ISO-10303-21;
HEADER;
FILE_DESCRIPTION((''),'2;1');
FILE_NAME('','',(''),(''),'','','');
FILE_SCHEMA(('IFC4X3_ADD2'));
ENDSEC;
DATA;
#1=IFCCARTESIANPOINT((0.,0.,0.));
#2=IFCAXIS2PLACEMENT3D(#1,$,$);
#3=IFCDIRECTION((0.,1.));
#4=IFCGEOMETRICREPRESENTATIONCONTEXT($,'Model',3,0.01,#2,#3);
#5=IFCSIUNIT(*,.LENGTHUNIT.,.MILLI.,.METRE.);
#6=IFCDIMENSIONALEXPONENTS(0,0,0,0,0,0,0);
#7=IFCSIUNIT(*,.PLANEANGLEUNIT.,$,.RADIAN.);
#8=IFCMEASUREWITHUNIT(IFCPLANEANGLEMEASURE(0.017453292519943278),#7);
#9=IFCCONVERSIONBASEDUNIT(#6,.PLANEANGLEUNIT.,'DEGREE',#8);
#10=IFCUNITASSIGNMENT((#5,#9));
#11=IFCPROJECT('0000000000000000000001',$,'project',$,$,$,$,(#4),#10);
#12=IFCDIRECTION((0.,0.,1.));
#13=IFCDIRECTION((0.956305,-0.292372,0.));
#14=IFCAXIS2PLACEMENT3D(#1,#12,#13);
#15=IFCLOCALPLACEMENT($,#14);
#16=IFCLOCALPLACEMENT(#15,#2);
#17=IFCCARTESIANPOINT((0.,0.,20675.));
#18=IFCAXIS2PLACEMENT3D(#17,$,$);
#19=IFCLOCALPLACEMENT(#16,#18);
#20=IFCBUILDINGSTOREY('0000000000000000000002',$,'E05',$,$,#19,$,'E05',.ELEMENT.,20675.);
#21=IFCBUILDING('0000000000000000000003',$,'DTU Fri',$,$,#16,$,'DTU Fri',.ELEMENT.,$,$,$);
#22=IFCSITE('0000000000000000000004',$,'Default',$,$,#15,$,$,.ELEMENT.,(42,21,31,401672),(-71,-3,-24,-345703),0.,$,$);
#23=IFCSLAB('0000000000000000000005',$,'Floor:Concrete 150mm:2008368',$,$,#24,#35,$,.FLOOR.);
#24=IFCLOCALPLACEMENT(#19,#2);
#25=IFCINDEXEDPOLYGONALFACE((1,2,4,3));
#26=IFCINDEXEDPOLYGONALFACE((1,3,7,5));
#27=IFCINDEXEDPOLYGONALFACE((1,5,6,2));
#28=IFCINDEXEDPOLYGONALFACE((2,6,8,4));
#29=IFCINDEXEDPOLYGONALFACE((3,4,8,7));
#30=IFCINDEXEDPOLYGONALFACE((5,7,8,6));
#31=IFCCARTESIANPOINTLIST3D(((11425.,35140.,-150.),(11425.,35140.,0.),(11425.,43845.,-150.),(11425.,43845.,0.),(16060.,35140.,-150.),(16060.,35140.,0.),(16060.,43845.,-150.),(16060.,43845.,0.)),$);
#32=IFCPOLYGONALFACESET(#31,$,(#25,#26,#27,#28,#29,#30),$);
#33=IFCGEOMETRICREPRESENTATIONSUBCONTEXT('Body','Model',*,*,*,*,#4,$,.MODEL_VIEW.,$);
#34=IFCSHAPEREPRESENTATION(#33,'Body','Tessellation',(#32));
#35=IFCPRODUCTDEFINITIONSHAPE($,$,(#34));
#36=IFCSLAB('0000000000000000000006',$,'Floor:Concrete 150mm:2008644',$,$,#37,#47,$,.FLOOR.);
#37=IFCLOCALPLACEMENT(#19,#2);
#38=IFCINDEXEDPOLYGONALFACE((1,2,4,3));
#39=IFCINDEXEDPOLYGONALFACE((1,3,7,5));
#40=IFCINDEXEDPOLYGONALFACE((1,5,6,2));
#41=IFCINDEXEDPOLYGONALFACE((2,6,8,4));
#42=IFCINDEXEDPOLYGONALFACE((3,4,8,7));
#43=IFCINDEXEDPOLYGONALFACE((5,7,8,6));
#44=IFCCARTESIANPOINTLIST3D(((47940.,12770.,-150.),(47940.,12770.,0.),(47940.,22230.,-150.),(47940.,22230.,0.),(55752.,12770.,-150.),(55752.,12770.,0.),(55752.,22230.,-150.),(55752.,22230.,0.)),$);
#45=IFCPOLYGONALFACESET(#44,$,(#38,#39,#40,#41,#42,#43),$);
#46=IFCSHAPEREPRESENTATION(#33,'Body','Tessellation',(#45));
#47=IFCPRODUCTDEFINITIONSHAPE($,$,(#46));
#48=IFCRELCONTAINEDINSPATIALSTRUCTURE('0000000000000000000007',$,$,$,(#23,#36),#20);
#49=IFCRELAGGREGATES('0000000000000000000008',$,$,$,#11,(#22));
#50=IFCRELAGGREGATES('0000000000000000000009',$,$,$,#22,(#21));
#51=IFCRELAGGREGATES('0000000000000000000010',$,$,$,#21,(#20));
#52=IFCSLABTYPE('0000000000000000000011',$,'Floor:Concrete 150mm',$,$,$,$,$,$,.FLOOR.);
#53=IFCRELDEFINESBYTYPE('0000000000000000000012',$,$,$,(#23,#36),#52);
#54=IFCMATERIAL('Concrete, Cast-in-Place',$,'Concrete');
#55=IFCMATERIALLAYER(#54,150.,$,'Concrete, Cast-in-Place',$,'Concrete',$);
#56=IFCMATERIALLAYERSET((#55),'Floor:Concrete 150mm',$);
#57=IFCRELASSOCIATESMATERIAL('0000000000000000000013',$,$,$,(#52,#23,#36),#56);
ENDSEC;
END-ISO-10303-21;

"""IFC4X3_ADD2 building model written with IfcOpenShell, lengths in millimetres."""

from ifc_helpers import new_model, entity, si_unit, converted_unit, direction, frame, frame_2d, origin, place, context, subcontext, project, spatial, rectangle, extrude, material, layer, layer_set, layer_usage, type_object, element, save


model = new_model("IFC4X3_ADD2")

# Units and contexts
model_context = context("Model", 3, precision=0.01, world=origin(), true_north=direction((0.0, 1.0)))
body_context = subcontext(model_context, "Body", "Model", "MODEL_VIEW")
ifc_project = project(units=[si_unit("LENGTHUNIT", "METRE", prefix="MILLI"), converted_unit("PLANEANGLEUNIT", "DEGREE", entity("IfcPlaneAngleMeasure", 0.017453292519943278), si_unit("PLANEANGLEUNIT", "RADIAN"), dimensions=[0, 0, 0, 0, 0, 0, 0])], contexts=[model_context])

# Site, building, storey
site_placement = place(None, frame((0.0, 0.0, 0.0), z_axis=(0.0, 0.0, 1.0), x_axis=(0.956305, -0.292372, 0.0)))
site = spatial("IfcSite", under=ifc_project, at=site_placement, Name="Default", CompositionType="ELEMENT", RefLatitude=(42, 21, 31, 401672), RefLongitude=(-71, -3, -24, -345703), RefElevation=0.0)
building_placement = place(site_placement, origin())
building = spatial("IfcBuilding", under=site, at=building_placement, Name="DTU Fri", LongName="DTU Fri", CompositionType="ELEMENT")
storey_placement = place(building_placement, frame((0.0, 0.0, 20675.0)))
storey = spatial("IfcBuildingStorey", under=building, at=storey_placement, Name="E05", LongName="E05", CompositionType="ELEMENT", Elevation=20675.0)

# Slabs
ifc_material = material(Name="Concrete, Cast-in-Place", Category="Concrete")
ifc_layer = layer(ifc_material, 150.0, Name="Concrete, Cast-in-Place", Category="Concrete")
ifc_layer_set = layer_set([ifc_layer], Name="Floor:Concrete 150mm")
ifc_layer_usage_1 = layer_usage(ifc_layer_set, "AXIS3", "POSITIVE", 0.0)
slab_type = type_object("IfcSlabType", Name="Floor:Concrete 150mm", PredefinedType="FLOOR", material=ifc_layer_set)
slab_1_placement = place(storey_placement, origin())
element("IfcSlab", 1, at=slab_1_placement, inside=storey, type_object=slab_type, material=ifc_layer_usage_1, Name="Floor:Concrete 150mm:2008368", PredefinedType="FLOOR", context=body_context, shape_type="SweptSolid", body=[
    extrude(rectangle(XDim=8705.0, YDim=4635.0, at=frame_2d((0.0, 0.0), x_axis=(1.0, 0.0))), frame((13742.5, 39492.5, 0.0), z_axis=(0.0, 0.0, -1.0), x_axis=(0.0, 1.0, 0.0)), (0.0, 0.0, 1.0), 150.0),
])
ifc_layer_usage_2 = layer_usage(ifc_layer_set, "AXIS3", "POSITIVE", 0.0)
slab_2_placement = place(storey_placement, origin())
element("IfcSlab", 2, at=slab_2_placement, inside=storey, type_object=slab_type, material=ifc_layer_usage_2, Name="Floor:Concrete 150mm:2008644", PredefinedType="FLOOR", context=body_context, shape_type="SweptSolid", body=[
    extrude(rectangle(XDim=9460.0, YDim=7812.0, at=frame_2d((0.0, 0.0), x_axis=(1.0, 0.0))), frame((51846.0, 17500.0, 0.0), z_axis=(0.0, 0.0, -1.0), x_axis=(0.0, 1.0, 0.0)), (0.0, 0.0, 1.0), 150.0),
])

save(model, "model.ifc")
